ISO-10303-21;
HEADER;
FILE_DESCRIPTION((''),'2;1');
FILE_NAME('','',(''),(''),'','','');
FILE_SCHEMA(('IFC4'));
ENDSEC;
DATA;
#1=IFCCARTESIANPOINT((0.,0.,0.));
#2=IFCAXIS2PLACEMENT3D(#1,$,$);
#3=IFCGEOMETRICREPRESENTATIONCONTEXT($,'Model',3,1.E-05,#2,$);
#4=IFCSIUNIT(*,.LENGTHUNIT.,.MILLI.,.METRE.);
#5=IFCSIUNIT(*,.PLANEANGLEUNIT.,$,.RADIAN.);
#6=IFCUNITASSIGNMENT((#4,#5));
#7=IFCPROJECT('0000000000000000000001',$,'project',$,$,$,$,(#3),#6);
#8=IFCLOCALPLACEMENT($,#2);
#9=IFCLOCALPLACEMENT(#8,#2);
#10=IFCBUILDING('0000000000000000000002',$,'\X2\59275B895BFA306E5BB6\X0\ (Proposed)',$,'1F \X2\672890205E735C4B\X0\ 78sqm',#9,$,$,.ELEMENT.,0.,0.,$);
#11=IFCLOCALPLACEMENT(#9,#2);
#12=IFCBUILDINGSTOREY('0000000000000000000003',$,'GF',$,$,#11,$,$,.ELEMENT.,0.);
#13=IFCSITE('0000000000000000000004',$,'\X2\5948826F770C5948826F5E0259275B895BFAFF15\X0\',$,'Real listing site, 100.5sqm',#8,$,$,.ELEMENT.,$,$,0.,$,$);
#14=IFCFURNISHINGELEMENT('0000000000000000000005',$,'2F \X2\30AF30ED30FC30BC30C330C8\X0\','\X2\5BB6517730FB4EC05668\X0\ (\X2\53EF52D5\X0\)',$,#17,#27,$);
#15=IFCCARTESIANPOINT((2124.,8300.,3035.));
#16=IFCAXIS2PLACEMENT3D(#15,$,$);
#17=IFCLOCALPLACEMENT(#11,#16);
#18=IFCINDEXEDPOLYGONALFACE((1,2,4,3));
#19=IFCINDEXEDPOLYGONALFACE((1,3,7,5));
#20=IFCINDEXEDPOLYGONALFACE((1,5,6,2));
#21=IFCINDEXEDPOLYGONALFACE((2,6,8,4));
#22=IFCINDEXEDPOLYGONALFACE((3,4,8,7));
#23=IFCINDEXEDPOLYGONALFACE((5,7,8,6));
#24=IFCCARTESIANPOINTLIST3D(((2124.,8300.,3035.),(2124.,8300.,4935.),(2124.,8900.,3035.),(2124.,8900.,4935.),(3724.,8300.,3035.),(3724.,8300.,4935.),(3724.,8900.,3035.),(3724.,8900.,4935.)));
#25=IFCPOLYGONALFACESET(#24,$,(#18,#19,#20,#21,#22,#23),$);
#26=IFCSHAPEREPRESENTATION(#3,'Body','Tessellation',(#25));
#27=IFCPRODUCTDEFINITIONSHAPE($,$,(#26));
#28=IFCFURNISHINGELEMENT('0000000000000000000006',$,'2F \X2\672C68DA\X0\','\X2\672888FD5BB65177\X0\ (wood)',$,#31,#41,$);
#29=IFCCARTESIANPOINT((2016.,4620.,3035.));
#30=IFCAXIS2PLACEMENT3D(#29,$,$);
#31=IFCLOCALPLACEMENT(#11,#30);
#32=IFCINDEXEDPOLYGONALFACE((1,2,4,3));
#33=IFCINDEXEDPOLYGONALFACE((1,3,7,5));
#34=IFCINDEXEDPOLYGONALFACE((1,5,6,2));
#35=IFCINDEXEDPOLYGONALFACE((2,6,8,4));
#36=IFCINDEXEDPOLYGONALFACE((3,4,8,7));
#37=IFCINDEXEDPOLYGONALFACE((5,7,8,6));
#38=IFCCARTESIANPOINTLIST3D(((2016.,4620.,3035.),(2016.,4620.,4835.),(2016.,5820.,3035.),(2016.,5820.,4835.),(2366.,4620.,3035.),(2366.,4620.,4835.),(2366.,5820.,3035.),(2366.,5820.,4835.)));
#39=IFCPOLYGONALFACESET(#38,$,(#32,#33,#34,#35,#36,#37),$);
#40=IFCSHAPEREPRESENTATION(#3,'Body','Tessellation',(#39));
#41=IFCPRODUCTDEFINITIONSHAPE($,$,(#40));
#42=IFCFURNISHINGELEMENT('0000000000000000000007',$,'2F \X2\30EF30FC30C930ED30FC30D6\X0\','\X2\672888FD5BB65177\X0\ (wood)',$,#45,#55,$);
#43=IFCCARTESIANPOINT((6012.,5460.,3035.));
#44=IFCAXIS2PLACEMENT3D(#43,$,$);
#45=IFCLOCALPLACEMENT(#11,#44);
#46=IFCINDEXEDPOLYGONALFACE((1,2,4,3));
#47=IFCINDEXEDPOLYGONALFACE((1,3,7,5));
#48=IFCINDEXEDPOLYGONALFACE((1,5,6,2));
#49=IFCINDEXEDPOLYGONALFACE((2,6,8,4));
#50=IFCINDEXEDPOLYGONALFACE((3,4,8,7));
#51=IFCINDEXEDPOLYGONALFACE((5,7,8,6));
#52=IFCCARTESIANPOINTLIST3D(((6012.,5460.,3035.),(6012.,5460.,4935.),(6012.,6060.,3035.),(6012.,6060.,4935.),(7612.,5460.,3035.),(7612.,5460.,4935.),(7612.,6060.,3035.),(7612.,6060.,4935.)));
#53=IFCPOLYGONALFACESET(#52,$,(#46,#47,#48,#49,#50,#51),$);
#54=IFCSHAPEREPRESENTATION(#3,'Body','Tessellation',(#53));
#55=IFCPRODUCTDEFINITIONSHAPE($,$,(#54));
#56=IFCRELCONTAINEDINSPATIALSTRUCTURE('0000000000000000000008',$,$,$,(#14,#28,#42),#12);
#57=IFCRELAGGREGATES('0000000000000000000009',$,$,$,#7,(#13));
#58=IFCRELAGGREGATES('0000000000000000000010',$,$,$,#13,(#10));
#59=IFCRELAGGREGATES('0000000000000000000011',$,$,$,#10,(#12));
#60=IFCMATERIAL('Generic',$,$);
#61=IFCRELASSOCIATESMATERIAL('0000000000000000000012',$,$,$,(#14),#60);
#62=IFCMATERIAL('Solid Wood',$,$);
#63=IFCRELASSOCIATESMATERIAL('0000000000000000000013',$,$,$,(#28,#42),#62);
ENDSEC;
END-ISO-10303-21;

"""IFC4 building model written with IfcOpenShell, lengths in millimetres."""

from ifc_helpers import new_model, si_unit, frame, frame_2d, origin, place, context, project, spatial, rectangle, extrude, material, element, save


model = new_model("IFC4")

# Units and contexts
model_context = context("Model", 3, precision=1e-05, world=origin())
ifc_project = project(units=[si_unit("LENGTHUNIT", "METRE", prefix="MILLI"), si_unit("PLANEANGLEUNIT", "RADIAN")], contexts=[model_context])

# Site, building, storey
site_placement = place(None, origin())
site = spatial("IfcSite", under=ifc_project, at=site_placement, Name="奈良県奈良市大安寺５", ObjectType="Real listing site, 100.5sqm", CompositionType="ELEMENT", RefElevation=0.0)
building_placement = place(site_placement, origin())
building = spatial("IfcBuilding", under=site, at=building_placement, Name="大安寺の家 (Proposed)", ObjectType="1F 木造平屋 78sqm", CompositionType="ELEMENT", ElevationOfRefHeight=0.0, ElevationOfTerrain=0.0)
storey_placement = place(building_placement, origin())
storey = spatial("IfcBuildingStorey", under=building, at=storey_placement, Name="GF", CompositionType="ELEMENT", Elevation=0.0)

# Shared definitions
ifc_material_1 = material(Name="Solid Wood")

# Shared definitions
ifc_material_2 = material(Name="Generic")

# Furnishing elements
furnishing_1_placement = place(storey_placement, frame((2124.0, 8300.0, 3035.0)))
element("IfcFurnishingElement", 1, at=furnishing_1_placement, inside=storey, material=ifc_material_2, Name="2F クローゼット", Description="家具・什器 (可動)", context=model_context, shape_type="SweptSolid", body=[
    extrude(rectangle(XDim=1600.0, YDim=600.0, at=frame_2d((800.0, 300.0))), frame((2124.0, 8300.0, 3035.0)), (0.0, 0.0, 1.0), 1900.0),
])
furnishing_2_placement = place(storey_placement, frame((2016.0, 4620.0, 3035.0)))
element("IfcFurnishingElement", 2, at=furnishing_2_placement, inside=storey, material=ifc_material_1, Name="2F 本棚", Description="木製家具 (wood)", context=model_context, shape_type="SweptSolid", body=[
    extrude(rectangle(XDim=350.0, YDim=1200.0, at=frame_2d((175.0, 600.0))), frame((2016.0, 4620.0, 3035.0)), (0.0, 0.0, 1.0), 1800.0),
])
furnishing_3_placement = place(storey_placement, frame((6012.0, 5460.0, 3035.0)))
element("IfcFurnishingElement", 3, at=furnishing_3_placement, inside=storey, material=ifc_material_1, Name="2F ワードローブ", Description="木製家具 (wood)", context=model_context, shape_type="SweptSolid", body=[
    extrude(rectangle(XDim=1600.0, YDim=600.0, at=frame_2d((800.0, 300.0))), frame((6012.0, 5460.0, 3035.0)), (0.0, 0.0, 1.0), 1900.0),
])

save(model, "model.ifc")
